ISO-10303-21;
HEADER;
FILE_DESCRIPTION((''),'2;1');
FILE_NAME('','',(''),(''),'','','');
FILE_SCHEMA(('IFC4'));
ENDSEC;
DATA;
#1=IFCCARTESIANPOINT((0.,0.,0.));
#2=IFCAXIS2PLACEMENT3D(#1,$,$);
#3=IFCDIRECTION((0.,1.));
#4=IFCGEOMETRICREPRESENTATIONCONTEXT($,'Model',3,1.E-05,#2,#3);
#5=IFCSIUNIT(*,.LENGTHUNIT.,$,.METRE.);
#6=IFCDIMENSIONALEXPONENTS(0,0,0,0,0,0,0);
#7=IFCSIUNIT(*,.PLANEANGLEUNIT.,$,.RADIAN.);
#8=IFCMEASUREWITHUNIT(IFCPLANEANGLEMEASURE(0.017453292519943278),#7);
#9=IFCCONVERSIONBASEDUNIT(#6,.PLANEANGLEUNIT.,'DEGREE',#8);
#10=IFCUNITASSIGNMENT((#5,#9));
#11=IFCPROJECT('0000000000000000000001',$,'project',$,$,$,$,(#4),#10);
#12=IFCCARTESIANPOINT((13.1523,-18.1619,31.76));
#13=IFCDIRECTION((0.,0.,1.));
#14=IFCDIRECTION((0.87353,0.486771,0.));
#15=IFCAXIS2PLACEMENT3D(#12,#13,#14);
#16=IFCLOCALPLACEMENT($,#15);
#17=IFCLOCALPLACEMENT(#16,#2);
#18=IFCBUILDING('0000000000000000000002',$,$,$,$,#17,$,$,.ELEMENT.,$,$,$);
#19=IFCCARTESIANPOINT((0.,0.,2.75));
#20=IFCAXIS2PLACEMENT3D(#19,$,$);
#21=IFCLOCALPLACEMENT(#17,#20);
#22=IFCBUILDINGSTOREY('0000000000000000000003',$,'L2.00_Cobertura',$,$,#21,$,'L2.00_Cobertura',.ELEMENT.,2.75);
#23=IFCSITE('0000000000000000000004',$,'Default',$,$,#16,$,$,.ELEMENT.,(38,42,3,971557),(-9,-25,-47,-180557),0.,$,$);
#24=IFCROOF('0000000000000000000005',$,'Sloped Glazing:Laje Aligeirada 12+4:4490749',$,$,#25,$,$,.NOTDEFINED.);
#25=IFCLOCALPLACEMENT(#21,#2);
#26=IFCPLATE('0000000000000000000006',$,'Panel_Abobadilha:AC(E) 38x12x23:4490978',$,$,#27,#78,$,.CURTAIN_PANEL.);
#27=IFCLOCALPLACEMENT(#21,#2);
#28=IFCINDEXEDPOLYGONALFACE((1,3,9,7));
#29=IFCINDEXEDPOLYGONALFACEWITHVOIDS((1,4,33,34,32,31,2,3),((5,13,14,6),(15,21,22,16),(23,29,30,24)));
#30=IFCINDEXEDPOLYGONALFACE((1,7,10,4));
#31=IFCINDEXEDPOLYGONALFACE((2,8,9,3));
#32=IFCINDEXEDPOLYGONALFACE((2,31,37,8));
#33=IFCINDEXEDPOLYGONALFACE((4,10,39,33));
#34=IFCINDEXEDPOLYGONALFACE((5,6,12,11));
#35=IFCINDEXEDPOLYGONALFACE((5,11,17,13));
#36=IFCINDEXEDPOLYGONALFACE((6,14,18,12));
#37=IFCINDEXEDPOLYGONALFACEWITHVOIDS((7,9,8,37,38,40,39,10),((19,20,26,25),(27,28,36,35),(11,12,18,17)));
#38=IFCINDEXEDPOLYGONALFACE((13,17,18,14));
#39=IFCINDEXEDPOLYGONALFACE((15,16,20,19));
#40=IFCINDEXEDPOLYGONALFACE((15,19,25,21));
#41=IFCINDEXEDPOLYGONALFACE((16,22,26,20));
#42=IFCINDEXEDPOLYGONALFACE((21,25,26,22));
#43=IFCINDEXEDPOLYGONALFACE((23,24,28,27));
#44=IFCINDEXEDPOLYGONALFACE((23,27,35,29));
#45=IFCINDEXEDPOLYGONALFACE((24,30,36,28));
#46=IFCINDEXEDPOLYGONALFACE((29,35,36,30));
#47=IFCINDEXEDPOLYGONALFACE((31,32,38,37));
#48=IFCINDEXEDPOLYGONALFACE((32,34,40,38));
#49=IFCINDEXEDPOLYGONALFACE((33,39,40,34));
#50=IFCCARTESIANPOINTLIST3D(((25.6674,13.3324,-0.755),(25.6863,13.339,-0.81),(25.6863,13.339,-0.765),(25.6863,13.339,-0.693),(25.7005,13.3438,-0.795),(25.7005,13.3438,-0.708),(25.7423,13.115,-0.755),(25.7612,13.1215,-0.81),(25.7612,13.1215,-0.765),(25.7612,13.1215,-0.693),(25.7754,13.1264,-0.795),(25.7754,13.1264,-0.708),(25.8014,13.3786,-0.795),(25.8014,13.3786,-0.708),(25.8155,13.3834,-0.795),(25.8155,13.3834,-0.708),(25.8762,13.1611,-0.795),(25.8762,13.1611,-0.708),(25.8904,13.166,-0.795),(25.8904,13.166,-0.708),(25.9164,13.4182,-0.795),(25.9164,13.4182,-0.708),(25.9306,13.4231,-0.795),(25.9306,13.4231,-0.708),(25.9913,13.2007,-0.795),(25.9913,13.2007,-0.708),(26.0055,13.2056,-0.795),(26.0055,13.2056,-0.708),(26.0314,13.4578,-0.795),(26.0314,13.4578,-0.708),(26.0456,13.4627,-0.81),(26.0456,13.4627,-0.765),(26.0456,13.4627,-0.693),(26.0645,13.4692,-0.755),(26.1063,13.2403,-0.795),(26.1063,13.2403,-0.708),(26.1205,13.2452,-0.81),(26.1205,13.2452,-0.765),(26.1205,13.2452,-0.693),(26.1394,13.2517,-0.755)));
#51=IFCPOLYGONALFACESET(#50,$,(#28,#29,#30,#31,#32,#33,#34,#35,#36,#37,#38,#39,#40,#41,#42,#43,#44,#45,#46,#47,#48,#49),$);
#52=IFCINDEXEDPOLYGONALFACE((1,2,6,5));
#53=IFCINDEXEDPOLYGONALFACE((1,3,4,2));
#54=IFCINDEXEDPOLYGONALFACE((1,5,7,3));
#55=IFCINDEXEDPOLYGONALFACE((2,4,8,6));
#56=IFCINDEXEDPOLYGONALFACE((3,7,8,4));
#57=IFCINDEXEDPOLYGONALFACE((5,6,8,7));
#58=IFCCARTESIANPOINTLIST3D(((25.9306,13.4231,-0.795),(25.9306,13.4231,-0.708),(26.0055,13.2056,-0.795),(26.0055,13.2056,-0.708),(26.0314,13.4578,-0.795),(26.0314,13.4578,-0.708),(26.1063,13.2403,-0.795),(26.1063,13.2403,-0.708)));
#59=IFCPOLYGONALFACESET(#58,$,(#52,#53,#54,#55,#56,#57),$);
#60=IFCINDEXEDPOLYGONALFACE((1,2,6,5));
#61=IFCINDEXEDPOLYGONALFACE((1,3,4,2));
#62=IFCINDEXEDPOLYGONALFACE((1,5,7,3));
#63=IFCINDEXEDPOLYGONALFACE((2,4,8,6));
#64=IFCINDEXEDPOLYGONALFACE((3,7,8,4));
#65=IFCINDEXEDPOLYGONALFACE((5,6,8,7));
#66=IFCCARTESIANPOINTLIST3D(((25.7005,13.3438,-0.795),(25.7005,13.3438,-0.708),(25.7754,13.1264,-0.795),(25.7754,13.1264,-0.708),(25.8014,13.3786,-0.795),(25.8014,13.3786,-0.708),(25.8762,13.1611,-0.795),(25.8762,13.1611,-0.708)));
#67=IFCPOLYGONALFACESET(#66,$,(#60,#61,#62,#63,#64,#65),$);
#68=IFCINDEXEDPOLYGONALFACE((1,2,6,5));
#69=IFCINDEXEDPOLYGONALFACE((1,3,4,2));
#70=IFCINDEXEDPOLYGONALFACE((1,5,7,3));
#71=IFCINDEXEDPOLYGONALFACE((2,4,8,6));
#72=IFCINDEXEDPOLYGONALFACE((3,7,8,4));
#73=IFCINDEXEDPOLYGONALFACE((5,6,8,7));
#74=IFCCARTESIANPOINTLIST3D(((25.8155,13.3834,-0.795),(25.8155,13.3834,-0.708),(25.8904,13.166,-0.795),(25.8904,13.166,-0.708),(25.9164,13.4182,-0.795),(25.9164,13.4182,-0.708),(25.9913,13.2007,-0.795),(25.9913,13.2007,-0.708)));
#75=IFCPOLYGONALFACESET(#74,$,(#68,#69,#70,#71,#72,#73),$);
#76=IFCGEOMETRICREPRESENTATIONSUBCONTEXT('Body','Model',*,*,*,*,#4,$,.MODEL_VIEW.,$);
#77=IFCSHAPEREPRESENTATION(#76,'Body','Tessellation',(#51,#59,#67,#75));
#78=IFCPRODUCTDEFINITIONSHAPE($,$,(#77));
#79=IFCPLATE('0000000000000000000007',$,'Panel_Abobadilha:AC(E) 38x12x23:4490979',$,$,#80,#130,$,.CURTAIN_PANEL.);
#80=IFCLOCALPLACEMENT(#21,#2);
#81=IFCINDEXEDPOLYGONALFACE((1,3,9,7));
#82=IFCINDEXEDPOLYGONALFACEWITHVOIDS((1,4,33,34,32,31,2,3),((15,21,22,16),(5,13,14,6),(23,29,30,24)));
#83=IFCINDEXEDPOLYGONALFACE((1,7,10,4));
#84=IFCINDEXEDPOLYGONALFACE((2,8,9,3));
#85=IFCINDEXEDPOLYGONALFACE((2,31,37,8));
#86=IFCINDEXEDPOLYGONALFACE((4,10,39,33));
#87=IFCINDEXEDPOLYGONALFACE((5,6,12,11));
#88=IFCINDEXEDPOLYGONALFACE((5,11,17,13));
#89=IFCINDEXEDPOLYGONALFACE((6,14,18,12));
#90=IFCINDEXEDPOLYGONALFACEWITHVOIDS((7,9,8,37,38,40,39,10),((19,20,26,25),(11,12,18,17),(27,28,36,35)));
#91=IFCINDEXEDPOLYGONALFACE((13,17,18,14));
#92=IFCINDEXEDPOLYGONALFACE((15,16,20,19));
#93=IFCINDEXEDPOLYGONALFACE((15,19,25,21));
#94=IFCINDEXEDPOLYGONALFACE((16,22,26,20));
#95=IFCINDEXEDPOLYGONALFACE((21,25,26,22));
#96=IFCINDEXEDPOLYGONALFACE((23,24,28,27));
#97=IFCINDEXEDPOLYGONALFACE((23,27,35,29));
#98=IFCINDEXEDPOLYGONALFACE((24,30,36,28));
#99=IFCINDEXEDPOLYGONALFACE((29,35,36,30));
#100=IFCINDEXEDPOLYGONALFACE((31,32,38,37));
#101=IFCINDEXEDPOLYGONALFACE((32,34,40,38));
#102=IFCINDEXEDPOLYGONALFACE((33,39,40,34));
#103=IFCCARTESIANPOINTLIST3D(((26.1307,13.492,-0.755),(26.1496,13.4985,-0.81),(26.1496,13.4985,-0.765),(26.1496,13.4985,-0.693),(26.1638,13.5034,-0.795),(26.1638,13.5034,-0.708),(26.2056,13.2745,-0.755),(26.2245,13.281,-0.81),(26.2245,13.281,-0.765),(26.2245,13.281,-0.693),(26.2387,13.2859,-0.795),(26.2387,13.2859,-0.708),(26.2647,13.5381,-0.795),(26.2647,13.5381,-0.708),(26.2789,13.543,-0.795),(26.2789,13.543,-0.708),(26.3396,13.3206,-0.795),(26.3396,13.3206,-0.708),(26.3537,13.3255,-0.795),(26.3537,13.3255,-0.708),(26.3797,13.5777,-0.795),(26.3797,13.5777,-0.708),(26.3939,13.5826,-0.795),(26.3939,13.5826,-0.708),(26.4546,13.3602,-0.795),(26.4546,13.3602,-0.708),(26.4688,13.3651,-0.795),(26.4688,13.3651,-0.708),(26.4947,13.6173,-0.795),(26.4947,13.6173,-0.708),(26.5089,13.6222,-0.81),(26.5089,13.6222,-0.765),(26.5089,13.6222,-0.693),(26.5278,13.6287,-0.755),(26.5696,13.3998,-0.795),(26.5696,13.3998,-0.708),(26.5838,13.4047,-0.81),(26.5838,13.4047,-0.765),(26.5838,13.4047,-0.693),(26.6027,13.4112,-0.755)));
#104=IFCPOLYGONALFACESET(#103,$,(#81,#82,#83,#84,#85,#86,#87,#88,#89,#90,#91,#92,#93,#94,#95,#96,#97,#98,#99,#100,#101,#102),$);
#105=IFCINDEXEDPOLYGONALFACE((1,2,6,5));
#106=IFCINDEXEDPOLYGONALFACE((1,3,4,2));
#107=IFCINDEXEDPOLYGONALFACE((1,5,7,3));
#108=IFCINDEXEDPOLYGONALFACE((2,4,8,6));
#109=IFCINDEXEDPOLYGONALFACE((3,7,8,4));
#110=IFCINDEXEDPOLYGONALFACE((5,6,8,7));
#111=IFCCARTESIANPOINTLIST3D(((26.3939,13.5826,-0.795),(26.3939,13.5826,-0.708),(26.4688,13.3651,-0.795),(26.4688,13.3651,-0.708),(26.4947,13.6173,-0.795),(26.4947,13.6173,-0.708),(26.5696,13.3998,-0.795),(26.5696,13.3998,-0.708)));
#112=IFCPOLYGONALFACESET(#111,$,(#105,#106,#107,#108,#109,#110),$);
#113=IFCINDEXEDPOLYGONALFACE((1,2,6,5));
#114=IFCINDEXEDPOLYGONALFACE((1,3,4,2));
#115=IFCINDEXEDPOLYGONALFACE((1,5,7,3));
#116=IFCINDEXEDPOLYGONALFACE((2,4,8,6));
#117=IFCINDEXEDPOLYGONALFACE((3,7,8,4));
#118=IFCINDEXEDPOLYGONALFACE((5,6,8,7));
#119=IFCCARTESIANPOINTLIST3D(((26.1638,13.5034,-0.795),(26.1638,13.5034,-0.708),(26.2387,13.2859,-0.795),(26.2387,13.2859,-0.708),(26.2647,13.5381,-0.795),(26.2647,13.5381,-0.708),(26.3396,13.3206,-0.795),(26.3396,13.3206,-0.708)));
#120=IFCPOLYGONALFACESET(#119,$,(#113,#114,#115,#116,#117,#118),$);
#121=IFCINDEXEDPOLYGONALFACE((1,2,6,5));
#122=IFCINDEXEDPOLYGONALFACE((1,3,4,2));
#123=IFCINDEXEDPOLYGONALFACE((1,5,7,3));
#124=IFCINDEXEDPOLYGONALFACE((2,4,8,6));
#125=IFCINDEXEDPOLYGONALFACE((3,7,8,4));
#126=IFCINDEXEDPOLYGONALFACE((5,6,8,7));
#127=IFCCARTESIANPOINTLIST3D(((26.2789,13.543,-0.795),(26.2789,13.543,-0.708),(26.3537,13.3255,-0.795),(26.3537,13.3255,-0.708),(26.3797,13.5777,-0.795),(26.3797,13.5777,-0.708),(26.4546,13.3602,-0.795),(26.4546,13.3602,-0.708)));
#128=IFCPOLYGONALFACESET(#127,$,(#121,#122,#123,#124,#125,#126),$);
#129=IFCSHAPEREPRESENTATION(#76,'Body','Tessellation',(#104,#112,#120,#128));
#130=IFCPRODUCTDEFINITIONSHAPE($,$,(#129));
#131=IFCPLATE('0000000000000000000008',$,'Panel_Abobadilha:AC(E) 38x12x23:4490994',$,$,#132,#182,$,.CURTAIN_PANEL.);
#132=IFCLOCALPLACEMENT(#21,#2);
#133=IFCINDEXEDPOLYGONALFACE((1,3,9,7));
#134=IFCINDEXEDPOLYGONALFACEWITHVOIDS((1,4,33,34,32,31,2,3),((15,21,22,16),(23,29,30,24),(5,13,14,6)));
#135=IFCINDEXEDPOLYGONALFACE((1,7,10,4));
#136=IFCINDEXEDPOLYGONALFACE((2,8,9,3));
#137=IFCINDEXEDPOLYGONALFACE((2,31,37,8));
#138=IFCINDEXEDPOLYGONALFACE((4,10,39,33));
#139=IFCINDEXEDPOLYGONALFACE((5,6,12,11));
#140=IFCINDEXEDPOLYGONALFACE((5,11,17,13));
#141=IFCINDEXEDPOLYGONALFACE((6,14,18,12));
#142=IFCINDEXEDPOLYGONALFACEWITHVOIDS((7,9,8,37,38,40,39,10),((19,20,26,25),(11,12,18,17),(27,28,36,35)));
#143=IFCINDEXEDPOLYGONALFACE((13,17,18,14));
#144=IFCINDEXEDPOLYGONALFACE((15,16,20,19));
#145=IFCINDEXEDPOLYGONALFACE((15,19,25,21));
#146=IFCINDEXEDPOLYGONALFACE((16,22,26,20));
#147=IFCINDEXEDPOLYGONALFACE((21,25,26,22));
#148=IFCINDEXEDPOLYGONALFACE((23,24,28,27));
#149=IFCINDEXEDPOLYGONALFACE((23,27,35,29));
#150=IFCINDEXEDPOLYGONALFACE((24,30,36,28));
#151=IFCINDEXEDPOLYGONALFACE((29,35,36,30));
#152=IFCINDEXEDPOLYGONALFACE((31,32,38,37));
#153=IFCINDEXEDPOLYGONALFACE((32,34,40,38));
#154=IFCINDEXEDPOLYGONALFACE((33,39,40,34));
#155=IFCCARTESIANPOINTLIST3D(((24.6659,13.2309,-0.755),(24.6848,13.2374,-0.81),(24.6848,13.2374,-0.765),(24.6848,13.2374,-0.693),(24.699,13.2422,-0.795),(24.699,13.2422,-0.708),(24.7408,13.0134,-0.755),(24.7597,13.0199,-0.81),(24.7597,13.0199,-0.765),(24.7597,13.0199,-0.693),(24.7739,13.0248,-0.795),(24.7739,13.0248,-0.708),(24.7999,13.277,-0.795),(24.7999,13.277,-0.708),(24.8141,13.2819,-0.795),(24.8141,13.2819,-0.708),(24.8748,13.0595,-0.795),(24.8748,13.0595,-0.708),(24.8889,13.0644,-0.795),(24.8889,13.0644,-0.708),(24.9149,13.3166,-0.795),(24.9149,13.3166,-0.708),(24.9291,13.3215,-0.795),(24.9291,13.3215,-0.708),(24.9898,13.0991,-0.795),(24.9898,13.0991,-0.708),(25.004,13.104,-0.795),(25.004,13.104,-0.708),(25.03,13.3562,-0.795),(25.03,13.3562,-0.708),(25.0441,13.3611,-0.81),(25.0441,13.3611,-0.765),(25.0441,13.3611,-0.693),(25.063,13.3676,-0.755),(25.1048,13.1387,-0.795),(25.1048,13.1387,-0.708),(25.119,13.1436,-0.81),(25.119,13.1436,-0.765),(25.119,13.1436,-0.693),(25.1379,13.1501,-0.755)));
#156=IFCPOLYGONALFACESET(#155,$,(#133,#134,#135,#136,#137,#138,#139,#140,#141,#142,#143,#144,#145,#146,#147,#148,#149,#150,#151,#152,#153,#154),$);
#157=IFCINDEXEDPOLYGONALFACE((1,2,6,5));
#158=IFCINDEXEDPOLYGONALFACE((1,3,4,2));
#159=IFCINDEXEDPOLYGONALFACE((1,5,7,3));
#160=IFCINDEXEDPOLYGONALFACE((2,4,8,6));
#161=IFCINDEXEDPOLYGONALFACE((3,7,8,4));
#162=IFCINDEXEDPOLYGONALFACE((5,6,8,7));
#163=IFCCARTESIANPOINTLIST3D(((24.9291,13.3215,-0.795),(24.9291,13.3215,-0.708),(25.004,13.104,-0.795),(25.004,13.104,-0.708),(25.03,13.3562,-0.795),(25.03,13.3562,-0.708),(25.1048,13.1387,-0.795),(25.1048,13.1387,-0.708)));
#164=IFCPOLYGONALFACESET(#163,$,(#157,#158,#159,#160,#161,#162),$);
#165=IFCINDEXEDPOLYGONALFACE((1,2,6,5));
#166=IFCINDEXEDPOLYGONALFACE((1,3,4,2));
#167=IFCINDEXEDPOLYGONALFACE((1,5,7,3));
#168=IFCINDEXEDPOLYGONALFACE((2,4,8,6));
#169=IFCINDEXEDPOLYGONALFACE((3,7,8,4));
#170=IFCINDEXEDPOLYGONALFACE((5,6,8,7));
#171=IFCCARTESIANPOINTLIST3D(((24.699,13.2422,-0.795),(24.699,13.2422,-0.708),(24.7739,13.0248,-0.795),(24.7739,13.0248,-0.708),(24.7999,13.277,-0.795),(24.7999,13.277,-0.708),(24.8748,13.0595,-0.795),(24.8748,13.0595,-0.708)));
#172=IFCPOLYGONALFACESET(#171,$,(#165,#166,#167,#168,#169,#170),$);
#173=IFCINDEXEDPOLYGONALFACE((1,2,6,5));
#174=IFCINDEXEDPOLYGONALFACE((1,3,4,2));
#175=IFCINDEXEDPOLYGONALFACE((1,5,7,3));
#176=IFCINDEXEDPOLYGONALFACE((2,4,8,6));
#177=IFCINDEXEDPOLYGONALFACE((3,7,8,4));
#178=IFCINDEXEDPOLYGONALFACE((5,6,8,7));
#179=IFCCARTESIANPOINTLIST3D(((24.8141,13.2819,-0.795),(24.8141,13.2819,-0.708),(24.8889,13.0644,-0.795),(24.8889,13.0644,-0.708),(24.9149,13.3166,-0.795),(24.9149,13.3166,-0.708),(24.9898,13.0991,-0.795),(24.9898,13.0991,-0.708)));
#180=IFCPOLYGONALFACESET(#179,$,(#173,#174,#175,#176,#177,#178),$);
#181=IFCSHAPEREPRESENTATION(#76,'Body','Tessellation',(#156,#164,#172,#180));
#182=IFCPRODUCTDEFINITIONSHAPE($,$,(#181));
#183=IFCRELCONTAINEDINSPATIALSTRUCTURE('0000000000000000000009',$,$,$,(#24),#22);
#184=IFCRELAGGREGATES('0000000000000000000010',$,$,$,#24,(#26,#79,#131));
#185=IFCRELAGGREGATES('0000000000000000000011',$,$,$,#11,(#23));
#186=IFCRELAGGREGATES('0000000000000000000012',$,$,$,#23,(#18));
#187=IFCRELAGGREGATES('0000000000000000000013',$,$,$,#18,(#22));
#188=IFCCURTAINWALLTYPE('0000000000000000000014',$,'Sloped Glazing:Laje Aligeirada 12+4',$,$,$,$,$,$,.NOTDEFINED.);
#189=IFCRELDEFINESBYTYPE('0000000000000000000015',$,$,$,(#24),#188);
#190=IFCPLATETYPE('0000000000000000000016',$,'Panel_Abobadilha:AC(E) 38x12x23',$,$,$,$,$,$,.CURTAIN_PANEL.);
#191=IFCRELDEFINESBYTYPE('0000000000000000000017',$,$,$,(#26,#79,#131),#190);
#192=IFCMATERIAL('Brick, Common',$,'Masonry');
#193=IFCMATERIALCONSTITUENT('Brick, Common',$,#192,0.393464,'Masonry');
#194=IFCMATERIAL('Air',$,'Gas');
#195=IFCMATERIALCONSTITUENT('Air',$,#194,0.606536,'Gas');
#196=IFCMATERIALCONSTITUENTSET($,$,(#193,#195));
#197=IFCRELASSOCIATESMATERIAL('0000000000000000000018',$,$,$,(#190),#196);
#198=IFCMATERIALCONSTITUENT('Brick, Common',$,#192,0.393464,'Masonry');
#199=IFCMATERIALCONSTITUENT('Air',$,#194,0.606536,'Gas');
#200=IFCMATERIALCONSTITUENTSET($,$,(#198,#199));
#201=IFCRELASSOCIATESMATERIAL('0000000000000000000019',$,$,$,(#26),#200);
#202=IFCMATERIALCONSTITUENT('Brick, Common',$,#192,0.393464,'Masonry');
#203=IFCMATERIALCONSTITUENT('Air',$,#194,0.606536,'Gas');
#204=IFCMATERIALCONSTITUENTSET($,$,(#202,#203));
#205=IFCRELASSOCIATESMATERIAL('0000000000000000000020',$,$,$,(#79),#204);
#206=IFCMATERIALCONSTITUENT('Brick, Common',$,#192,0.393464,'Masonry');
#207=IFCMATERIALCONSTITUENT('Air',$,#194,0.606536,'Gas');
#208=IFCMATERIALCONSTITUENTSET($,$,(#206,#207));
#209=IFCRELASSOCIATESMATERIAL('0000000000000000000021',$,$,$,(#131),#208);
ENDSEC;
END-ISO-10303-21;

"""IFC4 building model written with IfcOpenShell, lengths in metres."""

from ifc_helpers import new_model, entity, si_unit, converted_unit, direction, frame, origin, place, context, subcontext, project, spatial, indexed_curve, outline, extrude, source, transform, mapped, material, constituent, constituent_set, type_object, type_shapes, element, aggregate, save


model = new_model("IFC4")

# Units and contexts
model_context = context("Model", 3, precision=1e-05, world=origin(), true_north=direction((0.0, 1.0)))
body_context = subcontext(model_context, "Body", "Model", "MODEL_VIEW")
ifc_project = project(units=[si_unit("LENGTHUNIT", "METRE"), converted_unit("PLANEANGLEUNIT", "DEGREE", entity("IfcPlaneAngleMeasure", 0.017453292519943278), si_unit("PLANEANGLEUNIT", "RADIAN"), dimensions=[0, 0, 0, 0, 0, 0, 0])], contexts=[model_context])

# Site, building, storey
site_placement = place(None, frame((13.1523, -18.1619, 31.76), z_axis=(0.0, 0.0, 1.0), x_axis=(0.87353, 0.486771, 0.0)))
site = spatial("IfcSite", under=ifc_project, at=site_placement, Name="Default", CompositionType="ELEMENT", RefLatitude=(38, 42, 3, 971557), RefLongitude=(-9, -25, -47, -180557), RefElevation=0.0)
building_placement = place(site_placement, origin())
building = spatial("IfcBuilding", under=site, at=building_placement, CompositionType="ELEMENT")
storey_placement = place(building_placement, frame((0.0, 0.0, 2.75)))
storey = spatial("IfcBuildingStorey", under=building, at=storey_placement, Name="L2.00_Cobertura", LongName="L2.00_Cobertura", CompositionType="ELEMENT", Elevation=2.75)

# Roof, plates
curtain_wall_type = type_object("IfcCurtainWallType", Name="Sloped Glazing:Laje Aligeirada 12+4", PredefinedType="NOTDEFINED")
roof_placement = place(storey_placement, frame((0.0, 0.0, -2.75)))
roof = element("IfcRoof", 1, at=roof_placement, inside=storey, type_object=curtain_wall_type, Name="Sloped Glazing:Laje Aligeirada 12+4:4490749", PredefinedType="NOTDEFINED")
ifc_material_1 = material(Name="Brick, Common", Category="Masonry")
ifc_material_2 = material(Name="Air", Category="Gas")
ifc_constituent_1 = constituent(ifc_material_1, Name="Brick, Common", Category="Masonry", fraction=0.393464)
ifc_constituent_2 = constituent(ifc_material_2, Name="Air", Category="Gas", fraction=0.606536)
ifc_constituent_set_1 = constituent_set(constituents=[ifc_constituent_1, ifc_constituent_2])
plate_type = type_object("IfcPlateType", Name="Panel_Abobadilha:AC(E) 38x12x23", PredefinedType="CURTAIN_PANEL", material=ifc_constituent_set_1)
shared_shape_1 = source(origin(), body_context, "Body", "SweptSolid", [
    extrude(outline(indexed_curve([(-0.19, -0.0543), (0.19, -0.0543), (0.19, -0.0093), (0.21, 0.0007), (0.19, 0.0628), (-0.19, 0.0628), (-0.21, 0.0007), (-0.19, -0.0093), (-0.19, -0.0543)], self_intersect=False), holes=[indexed_curve([(-0.0683, 0.0477), (-0.0683, -0.0393), (-0.175, -0.0393), (-0.175, 0.0477), (-0.0683, 0.0477)], self_intersect=False), indexed_curve([(0.0533, 0.0477), (0.0533, -0.0393), (-0.0533, -0.0393), (-0.0533, 0.0477), (0.0533, 0.0477)], self_intersect=False), indexed_curve([(0.175, 0.0477), (0.175, -0.0393), (0.0683, -0.0393), (0.0683, 0.0477), (0.175, 0.0477)], self_intersect=False)]), frame((0.0, 0.0543, 0.0)), (0.0, 0.0, 1.0), 0.23),
    extrude(outline(indexed_curve([(-0.0533, -0.0435), (0.0533, -0.0435), (0.0533, 0.0435), (-0.0533, 0.0435), (-0.0533, -0.0435)], self_intersect=False)), frame((0.1217, 0.0585, 0.0), z_axis=(0.0, 0.0, 1.0), x_axis=(-1.0, 0.0, 0.0)), (0.0, 0.0, 1.0), 0.23),
    extrude(outline(indexed_curve([(-0.0533, -0.0435), (0.0533, -0.0435), (0.0533, 0.0435), (-0.0533, 0.0435), (-0.0533, -0.0435)], self_intersect=False)), frame((-0.1217, 0.0585, 0.0), z_axis=(0.0, 0.0, 1.0), x_axis=(-1.0, 0.0, 0.0)), (0.0, 0.0, 1.0), 0.23),
    extrude(outline(indexed_curve([(-0.0533, -0.0435), (0.0533, -0.0435), (0.0533, 0.0435), (-0.0533, 0.0435), (-0.0533, -0.0435)], self_intersect=False)), frame((0.0, 0.0585, 0.0), z_axis=(0.0, 0.0, 1.0), x_axis=(-1.0, 0.0, 0.0)), (0.0, 0.0, 1.0), 0.23),
])
type_shapes(plate_type, [shared_shape_1])
ifc_constituent_3 = constituent(ifc_material_1, Name="Brick, Common", Category="Masonry", fraction=0.393464)
ifc_constituent_4 = constituent(ifc_material_2, Name="Air", Category="Gas", fraction=0.606536)
ifc_constituent_set_2 = constituent_set(constituents=[ifc_constituent_3, ifc_constituent_4])
plate_1_placement = place(roof_placement, frame((25.866, 13.4008, 1.94), z_axis=(0.325568, -0.945519, 0.0), x_axis=(0.945519, 0.325568, 0.0)))
plate_1 = element("IfcPlate", 2, at=plate_1_placement, type_object=plate_type, material=ifc_constituent_set_2, Name="Panel_Abobadilha:AC(E) 38x12x23:4490978", PredefinedType="CURTAIN_PANEL", context=body_context, shape_type="MappedRepresentation", body=[
    mapped(shared_shape_1, transform((0.0, 0.0, 0.0), scale=1.0)),
])
ifc_constituent_5 = constituent(ifc_material_1, Name="Brick, Common", Category="Masonry", fraction=0.393464)
ifc_constituent_6 = constituent(ifc_material_2, Name="Air", Category="Gas", fraction=0.606536)
ifc_constituent_set_3 = constituent_set(constituents=[ifc_constituent_5, ifc_constituent_6])
plate_2_placement = place(roof_placement, frame((26.3293, 13.5603, 1.94), z_axis=(0.325568, -0.945519, 0.0), x_axis=(0.945519, 0.325568, 0.0)))
plate_2 = element("IfcPlate", 3, at=plate_2_placement, type_object=plate_type, material=ifc_constituent_set_3, Name="Panel_Abobadilha:AC(E) 38x12x23:4490979", PredefinedType="CURTAIN_PANEL", context=body_context, shape_type="MappedRepresentation", body=[
    mapped(shared_shape_1, transform((0.0, 0.0, 0.0), scale=1.0)),
])
ifc_constituent_7 = constituent(ifc_material_1, Name="Brick, Common", Category="Masonry", fraction=0.393464)
ifc_constituent_8 = constituent(ifc_material_2, Name="Air", Category="Gas", fraction=0.606536)
ifc_constituent_set_4 = constituent_set(constituents=[ifc_constituent_7, ifc_constituent_8])
plate_3_placement = place(roof_placement, frame((24.8645, 13.2992, 1.94), z_axis=(0.325568, -0.945519, 0.0), x_axis=(0.945519, 0.325568, 0.0)))
plate_3 = element("IfcPlate", 4, at=plate_3_placement, type_object=plate_type, material=ifc_constituent_set_4, Name="Panel_Abobadilha:AC(E) 38x12x23:4490994", PredefinedType="CURTAIN_PANEL", context=body_context, shape_type="MappedRepresentation", body=[
    mapped(shared_shape_1, transform((0.0, 0.0, 0.0), scale=1.0)),
])
aggregate(roof, [plate_1, plate_2, plate_3])

save(model, "model.ifc")
